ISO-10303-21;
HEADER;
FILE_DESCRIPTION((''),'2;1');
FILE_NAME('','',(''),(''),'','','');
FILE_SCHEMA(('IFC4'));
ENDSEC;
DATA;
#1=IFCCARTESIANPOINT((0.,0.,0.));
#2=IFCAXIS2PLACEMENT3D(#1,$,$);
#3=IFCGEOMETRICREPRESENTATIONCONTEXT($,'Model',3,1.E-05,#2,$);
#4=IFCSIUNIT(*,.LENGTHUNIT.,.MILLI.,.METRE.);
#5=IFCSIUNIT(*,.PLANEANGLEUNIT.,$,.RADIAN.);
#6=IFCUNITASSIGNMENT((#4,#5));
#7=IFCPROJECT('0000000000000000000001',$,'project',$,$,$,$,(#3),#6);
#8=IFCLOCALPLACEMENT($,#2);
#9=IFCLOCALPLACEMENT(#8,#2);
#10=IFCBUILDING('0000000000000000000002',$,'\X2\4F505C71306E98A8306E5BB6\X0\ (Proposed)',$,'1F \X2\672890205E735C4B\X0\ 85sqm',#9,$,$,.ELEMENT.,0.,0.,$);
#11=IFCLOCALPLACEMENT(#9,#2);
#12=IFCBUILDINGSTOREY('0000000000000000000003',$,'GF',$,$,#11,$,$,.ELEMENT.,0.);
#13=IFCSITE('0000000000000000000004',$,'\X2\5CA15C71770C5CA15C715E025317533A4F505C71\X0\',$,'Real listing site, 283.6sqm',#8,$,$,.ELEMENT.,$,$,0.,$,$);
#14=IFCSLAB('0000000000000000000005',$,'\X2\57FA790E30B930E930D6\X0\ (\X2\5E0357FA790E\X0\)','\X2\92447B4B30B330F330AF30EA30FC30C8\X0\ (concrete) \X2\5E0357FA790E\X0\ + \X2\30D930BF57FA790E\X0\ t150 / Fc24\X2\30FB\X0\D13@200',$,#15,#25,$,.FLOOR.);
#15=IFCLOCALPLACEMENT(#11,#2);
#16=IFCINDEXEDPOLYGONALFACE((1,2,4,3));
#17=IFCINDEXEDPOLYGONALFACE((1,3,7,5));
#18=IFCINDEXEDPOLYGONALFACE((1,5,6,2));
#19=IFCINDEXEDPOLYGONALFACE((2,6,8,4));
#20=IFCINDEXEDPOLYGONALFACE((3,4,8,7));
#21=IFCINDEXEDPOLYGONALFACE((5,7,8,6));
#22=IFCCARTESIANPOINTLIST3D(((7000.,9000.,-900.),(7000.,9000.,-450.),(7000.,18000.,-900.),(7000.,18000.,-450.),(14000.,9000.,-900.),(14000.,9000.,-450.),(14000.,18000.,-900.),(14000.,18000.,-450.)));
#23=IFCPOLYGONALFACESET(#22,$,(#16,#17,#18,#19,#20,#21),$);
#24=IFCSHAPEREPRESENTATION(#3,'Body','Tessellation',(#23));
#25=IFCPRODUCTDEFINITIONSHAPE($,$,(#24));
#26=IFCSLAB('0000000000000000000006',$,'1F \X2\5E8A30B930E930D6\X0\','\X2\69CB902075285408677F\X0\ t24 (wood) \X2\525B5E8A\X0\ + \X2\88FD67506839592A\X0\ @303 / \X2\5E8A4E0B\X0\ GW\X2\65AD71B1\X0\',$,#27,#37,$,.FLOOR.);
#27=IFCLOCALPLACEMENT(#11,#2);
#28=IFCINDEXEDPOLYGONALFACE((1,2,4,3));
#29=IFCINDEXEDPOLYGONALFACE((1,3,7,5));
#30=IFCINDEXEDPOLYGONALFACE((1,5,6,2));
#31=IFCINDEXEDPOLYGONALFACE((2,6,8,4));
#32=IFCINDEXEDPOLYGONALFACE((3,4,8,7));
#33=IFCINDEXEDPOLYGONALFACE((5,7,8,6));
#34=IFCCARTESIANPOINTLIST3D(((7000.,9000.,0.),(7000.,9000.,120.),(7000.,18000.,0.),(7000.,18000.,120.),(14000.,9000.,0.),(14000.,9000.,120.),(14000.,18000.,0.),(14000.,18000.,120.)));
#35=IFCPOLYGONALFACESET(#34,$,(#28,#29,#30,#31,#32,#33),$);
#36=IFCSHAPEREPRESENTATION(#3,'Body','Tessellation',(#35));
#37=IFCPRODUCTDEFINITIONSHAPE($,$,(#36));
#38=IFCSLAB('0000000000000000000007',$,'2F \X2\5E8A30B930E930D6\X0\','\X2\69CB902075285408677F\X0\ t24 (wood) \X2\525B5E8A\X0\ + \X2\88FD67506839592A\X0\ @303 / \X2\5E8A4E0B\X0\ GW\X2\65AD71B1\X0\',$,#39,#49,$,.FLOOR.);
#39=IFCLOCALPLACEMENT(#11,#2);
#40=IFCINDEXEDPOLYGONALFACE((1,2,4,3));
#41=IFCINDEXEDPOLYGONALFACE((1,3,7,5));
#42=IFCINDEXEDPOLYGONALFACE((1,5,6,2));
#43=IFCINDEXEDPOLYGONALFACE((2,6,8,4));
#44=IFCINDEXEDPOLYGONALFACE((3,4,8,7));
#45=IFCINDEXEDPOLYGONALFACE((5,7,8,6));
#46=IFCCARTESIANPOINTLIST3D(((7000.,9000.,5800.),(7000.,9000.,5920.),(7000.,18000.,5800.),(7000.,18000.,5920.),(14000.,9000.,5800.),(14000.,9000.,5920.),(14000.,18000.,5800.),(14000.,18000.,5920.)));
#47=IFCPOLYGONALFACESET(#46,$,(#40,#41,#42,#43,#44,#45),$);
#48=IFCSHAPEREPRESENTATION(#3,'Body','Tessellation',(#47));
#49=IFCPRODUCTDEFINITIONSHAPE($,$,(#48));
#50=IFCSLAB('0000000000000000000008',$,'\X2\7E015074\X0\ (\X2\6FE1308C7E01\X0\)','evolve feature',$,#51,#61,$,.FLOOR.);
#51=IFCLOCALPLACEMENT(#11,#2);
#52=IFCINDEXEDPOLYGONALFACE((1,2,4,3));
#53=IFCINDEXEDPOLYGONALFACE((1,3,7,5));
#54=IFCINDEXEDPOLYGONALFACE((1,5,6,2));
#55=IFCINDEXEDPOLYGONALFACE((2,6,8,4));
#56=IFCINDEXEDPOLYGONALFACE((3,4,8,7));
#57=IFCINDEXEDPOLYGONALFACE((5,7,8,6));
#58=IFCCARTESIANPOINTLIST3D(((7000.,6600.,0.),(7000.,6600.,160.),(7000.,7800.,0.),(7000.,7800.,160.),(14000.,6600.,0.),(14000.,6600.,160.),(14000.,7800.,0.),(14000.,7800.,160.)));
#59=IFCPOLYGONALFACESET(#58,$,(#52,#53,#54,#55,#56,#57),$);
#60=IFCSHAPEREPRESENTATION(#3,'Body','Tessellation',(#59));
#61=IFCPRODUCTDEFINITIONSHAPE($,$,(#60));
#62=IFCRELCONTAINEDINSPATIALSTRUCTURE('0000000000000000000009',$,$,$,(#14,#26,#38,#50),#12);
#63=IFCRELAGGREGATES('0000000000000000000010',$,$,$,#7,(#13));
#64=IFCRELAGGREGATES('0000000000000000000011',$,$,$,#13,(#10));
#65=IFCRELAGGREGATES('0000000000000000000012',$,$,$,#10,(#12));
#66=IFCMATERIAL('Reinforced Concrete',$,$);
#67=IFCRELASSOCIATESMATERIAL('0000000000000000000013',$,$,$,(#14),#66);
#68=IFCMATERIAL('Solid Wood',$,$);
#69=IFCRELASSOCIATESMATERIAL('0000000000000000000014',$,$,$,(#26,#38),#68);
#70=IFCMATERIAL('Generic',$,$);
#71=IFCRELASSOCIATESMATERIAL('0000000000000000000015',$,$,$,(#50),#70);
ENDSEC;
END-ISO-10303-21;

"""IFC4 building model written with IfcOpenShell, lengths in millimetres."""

from ifc_helpers import new_model, si_unit, frame, frame_2d, origin, place, context, project, spatial, rectangle, extrude, material, element, save


model = new_model("IFC4")

# Units and contexts
model_context = context("Model", 3, precision=1e-05, world=origin())
ifc_project = project(units=[si_unit("LENGTHUNIT", "METRE", prefix="MILLI"), si_unit("PLANEANGLEUNIT", "RADIAN")], contexts=[model_context])

# Site, building, storey
site_placement = place(None, origin())
site = spatial("IfcSite", under=ifc_project, at=site_placement, Name="岡山県岡山市北区佐山", ObjectType="Real listing site, 283.6sqm", CompositionType="ELEMENT", RefElevation=0.0)
building_placement = place(site_placement, origin())
building = spatial("IfcBuilding", under=site, at=building_placement, Name="佐山の風の家 (Proposed)", ObjectType="1F 木造平屋 85sqm", CompositionType="ELEMENT", ElevationOfRefHeight=0.0, ElevationOfTerrain=0.0)
storey_placement = place(building_placement, origin())
storey = spatial("IfcBuildingStorey", under=building, at=storey_placement, Name="GF", CompositionType="ELEMENT", Elevation=0.0)

# Slabs
ifc_material_1 = material(Name="Reinforced Concrete")
slab_1_placement = place(storey_placement, frame((3500.0, 4500.0, -450.0)))
element("IfcSlab", 1, at=slab_1_placement, inside=storey, material=ifc_material_1, Name="基礎スラブ (布基礎)", Description="鉄筋コンクリート (concrete) 布基礎 + ベタ基礎 t150 / Fc24・D13@200", PredefinedType="FLOOR", context=model_context, shape_type="SweptSolid", body=[
    extrude(rectangle(XDim=7000.0, YDim=9000.0, at=frame_2d((3500.0, 4500.0))), frame((3500.0, 4500.0, -450.0)), (0.0, 0.0, 1.0), 450.0),
])
ifc_material_2 = material(Name="Solid Wood")
slab_2_placement = place(storey_placement, frame((3500.0, 4500.0, 0.0)))
element("IfcSlab", 2, at=slab_2_placement, inside=storey, material=ifc_material_2, Name="1F 床スラブ", Description="構造用合板 t24 (wood) 剛床 + 製材根太 @303 / 床下 GW断熱", PredefinedType="FLOOR", context=model_context, shape_type="SweptSolid", body=[
    extrude(rectangle(XDim=7000.0, YDim=9000.0, at=frame_2d((3500.0, 4500.0))), frame((3500.0, 4500.0, 0.0)), (0.0, 0.0, 1.0), 120.0),
])
slab_3_placement = place(storey_placement, frame((3500.0, 4500.0, 2900.0)))
element("IfcSlab", 3, at=slab_3_placement, inside=storey, material=ifc_material_2, Name="2F 床スラブ", Description="構造用合板 t24 (wood) 剛床 + 製材根太 @303 / 床下 GW断熱", PredefinedType="FLOOR", context=model_context, shape_type="SweptSolid", body=[
    extrude(rectangle(XDim=7000.0, YDim=9000.0, at=frame_2d((3500.0, 4500.0))), frame((3500.0, 4500.0, 2900.0)), (0.0, 0.0, 1.0), 120.0),
])
ifc_material_3 = material(Name="Generic")
slab_4_placement = place(storey_placement, frame((3500.0, 3300.0, 0.0)))
element("IfcSlab", 4, at=slab_4_placement, inside=storey, material=ifc_material_3, Name="縁側 (濡れ縁)", Description="evolve feature", PredefinedType="FLOOR", context=model_context, shape_type="SweptSolid", body=[
    extrude(rectangle(XDim=7000.0, YDim=1200.0, at=frame_2d((3500.0, 600.0))), frame((3500.0, 3300.0, 0.0)), (0.0, 0.0, 1.0), 160.0),
])

save(model, "model.ifc")
